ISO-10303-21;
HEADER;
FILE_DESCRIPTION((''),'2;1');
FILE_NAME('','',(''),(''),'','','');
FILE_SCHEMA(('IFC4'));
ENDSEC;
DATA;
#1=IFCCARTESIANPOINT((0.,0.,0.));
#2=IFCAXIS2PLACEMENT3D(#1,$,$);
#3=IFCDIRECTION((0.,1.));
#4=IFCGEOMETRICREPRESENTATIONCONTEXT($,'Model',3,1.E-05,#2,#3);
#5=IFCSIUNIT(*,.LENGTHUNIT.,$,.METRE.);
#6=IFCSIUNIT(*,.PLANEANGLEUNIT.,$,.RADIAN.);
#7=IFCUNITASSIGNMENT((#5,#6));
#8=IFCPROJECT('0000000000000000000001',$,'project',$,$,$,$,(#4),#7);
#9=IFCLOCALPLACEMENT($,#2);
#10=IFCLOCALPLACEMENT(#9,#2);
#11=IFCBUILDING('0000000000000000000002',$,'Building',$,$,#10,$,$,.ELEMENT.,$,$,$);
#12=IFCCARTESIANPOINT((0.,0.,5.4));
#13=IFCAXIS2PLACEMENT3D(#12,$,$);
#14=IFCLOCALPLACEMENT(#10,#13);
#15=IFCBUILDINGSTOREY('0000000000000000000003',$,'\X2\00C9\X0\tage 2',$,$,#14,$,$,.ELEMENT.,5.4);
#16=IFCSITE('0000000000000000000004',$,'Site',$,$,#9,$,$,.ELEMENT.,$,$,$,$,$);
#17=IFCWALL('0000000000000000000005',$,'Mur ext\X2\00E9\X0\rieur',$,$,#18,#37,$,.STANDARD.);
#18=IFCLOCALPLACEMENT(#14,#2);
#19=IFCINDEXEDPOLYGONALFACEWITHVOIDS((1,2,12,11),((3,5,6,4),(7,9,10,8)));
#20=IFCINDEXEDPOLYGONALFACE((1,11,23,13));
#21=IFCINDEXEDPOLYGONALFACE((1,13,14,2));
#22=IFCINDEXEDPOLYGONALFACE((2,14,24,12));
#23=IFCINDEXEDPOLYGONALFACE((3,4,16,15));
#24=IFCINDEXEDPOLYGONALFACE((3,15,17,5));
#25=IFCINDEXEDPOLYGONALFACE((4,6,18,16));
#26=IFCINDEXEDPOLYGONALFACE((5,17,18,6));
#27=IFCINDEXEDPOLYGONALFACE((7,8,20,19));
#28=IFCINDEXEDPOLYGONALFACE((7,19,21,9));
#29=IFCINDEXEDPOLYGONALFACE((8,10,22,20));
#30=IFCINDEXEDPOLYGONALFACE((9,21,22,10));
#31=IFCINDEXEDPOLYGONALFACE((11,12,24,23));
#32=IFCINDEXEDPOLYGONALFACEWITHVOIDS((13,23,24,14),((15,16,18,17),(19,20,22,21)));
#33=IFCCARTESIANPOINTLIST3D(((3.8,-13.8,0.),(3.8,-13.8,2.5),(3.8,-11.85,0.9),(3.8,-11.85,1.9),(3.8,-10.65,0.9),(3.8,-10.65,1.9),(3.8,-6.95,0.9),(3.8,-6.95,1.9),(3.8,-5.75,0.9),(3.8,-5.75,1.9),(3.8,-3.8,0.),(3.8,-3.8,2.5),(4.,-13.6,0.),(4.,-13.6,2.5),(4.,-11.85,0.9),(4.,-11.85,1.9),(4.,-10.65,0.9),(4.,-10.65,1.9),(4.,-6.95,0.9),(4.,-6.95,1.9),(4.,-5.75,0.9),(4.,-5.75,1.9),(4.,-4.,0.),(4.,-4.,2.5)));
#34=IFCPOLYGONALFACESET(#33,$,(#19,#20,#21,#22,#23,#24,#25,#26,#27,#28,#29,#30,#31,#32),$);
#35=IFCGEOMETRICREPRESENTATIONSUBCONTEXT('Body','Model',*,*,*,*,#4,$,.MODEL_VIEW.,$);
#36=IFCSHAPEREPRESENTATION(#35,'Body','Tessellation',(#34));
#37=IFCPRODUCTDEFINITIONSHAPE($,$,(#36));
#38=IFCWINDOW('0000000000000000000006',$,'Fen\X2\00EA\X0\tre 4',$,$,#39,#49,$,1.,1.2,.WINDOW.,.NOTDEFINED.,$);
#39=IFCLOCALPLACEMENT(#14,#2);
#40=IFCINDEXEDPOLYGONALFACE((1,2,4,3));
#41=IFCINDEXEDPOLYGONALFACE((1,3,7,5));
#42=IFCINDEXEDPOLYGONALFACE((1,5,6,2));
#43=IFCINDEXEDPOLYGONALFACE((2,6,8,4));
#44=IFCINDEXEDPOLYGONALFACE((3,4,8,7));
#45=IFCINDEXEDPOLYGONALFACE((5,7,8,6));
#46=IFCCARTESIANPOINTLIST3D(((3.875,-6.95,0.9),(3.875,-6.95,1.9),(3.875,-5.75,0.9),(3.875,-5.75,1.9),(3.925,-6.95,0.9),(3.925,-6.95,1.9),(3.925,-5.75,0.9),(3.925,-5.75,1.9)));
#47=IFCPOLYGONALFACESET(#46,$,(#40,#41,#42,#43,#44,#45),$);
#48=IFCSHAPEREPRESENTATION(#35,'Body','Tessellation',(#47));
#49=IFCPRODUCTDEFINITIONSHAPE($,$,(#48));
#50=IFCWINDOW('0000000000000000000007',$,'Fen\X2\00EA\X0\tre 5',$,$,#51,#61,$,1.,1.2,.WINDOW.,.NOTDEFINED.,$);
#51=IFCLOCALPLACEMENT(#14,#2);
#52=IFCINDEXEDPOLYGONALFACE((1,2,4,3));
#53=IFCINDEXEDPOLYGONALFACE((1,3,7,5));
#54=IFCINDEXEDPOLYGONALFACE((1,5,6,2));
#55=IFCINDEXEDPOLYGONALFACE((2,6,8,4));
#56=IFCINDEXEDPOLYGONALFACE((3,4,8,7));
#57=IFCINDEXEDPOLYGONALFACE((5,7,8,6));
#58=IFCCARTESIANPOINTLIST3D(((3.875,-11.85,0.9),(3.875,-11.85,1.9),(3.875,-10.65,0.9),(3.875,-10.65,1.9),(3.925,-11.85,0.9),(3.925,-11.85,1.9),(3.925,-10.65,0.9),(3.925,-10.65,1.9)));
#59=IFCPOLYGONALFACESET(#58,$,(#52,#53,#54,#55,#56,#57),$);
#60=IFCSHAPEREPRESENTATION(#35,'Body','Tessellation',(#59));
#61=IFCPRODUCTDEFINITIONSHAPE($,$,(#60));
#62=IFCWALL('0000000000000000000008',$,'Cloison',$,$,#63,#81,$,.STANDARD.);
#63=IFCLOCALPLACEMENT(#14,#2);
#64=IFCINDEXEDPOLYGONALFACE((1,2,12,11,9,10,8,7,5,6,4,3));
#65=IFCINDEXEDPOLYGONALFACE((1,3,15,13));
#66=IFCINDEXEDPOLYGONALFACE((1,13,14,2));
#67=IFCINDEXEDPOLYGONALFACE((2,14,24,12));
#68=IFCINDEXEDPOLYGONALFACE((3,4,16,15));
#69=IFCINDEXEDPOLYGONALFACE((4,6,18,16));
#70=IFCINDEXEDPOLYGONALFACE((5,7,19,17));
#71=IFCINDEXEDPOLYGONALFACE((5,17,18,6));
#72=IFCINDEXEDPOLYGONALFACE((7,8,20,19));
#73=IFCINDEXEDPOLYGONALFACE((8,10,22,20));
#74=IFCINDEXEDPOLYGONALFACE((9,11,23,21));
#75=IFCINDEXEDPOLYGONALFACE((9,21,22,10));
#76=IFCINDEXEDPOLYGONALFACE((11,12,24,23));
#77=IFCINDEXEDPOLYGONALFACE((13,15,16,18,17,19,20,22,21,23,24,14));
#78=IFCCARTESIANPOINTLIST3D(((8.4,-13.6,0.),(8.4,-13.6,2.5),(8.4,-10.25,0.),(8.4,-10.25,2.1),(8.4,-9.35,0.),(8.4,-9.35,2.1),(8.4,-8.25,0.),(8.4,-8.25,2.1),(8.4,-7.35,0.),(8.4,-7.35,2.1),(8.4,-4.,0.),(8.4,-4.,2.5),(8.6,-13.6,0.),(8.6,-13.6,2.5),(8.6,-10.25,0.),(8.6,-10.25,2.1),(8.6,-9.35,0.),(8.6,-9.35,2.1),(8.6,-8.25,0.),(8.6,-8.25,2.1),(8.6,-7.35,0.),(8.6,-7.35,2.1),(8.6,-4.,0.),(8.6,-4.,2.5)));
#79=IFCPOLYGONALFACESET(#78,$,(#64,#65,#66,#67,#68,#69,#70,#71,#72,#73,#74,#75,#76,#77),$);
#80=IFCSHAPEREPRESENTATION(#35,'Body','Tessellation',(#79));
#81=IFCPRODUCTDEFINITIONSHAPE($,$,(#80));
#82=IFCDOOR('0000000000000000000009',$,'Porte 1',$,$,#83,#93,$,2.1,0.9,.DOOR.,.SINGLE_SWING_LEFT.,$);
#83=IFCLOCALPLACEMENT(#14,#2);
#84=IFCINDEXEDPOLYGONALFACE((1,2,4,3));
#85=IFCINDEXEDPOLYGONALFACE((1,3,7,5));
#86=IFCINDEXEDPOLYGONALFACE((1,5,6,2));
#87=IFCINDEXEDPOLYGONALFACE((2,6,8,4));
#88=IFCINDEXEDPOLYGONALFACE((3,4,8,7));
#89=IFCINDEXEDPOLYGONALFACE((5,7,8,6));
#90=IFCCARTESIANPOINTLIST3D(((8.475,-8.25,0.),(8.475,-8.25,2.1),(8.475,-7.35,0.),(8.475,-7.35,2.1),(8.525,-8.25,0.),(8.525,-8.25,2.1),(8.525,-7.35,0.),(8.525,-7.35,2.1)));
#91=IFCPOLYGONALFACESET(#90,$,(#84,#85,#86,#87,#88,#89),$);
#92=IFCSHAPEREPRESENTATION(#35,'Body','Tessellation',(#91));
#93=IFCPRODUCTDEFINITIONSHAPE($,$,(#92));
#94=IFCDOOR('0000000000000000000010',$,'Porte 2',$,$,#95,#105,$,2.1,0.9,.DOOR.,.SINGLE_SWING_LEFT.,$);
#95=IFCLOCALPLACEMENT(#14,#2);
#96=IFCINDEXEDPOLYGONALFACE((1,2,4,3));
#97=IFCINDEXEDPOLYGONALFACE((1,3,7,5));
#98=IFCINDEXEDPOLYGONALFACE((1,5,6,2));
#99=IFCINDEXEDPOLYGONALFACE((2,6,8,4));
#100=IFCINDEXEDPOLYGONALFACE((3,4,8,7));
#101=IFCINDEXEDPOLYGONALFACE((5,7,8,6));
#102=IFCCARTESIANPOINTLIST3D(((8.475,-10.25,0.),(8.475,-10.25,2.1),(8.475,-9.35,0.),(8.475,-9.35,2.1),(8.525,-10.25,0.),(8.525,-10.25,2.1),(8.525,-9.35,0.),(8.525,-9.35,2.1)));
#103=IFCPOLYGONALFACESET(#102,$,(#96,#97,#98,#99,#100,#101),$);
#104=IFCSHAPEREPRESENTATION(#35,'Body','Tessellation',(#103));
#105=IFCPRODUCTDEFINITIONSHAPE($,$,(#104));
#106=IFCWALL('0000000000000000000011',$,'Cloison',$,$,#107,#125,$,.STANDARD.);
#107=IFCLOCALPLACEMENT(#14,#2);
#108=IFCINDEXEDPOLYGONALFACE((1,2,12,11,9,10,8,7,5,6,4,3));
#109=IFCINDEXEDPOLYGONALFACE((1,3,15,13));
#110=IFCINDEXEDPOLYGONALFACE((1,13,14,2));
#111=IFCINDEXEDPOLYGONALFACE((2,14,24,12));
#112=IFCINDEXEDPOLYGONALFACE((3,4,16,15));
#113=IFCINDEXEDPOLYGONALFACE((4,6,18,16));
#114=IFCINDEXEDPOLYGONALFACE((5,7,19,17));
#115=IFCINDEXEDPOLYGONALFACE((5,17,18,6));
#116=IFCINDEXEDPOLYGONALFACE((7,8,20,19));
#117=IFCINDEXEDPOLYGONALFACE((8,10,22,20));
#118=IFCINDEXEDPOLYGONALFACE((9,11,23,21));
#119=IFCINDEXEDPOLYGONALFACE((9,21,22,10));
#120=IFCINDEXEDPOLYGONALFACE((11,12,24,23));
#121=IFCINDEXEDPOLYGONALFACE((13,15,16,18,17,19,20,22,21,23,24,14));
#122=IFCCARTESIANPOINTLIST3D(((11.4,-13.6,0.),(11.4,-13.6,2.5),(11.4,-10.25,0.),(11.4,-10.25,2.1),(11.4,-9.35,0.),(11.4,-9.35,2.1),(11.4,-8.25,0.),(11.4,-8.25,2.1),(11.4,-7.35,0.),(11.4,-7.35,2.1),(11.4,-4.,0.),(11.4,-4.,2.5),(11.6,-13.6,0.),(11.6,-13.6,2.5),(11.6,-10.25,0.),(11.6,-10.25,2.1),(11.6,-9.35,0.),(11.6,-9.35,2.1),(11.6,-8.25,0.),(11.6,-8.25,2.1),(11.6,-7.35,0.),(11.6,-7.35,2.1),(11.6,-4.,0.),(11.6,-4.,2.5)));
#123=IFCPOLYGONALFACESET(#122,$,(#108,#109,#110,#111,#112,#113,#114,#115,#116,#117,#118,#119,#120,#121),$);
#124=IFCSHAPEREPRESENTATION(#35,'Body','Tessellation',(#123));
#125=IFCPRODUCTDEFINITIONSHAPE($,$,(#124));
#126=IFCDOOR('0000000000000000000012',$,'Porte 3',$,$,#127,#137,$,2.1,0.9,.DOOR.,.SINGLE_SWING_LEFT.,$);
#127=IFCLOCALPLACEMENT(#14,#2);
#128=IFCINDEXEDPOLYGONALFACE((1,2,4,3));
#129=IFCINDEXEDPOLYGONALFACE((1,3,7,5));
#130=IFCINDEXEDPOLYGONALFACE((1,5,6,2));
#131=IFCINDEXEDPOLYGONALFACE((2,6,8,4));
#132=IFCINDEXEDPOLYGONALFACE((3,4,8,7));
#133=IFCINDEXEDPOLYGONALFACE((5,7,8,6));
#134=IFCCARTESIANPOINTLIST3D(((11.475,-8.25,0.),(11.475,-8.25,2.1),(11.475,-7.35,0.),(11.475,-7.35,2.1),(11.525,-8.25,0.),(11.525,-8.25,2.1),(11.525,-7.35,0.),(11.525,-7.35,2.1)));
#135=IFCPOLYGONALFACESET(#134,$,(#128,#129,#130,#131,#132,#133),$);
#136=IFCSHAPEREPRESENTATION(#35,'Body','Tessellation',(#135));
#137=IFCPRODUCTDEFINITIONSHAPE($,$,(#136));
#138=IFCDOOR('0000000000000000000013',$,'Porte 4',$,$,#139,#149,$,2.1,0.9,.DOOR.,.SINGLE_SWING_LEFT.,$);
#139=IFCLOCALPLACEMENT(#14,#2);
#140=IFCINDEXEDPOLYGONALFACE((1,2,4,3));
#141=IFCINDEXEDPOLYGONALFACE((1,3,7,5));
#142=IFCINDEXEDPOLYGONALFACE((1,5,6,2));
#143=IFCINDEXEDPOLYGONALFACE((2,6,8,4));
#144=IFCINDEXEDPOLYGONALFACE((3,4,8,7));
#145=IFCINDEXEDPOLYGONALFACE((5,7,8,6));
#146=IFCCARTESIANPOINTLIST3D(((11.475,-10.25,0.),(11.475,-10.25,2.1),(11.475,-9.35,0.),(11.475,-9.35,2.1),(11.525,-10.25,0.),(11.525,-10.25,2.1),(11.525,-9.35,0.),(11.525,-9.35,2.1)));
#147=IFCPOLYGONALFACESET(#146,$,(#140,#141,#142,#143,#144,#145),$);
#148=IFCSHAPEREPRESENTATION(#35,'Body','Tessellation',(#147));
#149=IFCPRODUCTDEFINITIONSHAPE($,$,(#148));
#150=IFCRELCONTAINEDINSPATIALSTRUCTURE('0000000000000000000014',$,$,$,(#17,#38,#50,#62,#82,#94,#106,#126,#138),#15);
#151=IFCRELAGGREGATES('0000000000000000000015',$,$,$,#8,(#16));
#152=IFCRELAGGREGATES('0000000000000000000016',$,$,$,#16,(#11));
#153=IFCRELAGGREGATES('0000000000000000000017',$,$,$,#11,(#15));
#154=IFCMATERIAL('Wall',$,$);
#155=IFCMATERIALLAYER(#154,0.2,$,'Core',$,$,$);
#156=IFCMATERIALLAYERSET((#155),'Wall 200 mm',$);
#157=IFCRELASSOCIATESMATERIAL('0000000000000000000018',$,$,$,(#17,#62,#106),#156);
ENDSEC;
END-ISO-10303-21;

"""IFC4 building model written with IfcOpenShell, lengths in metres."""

from ifc_helpers import new_model, si_unit, direction, frame, origin, origin_2d, place, context, subcontext, project, spatial, polyline, rectangle, outline, extrude, material, layer, layer_set, layer_usage, element, fill, save


model = new_model("IFC4")

# Units and contexts
model_context = context("Model", 3, precision=1e-05, world=origin(), true_north=direction((0.0, 1.0)))
body_context = subcontext(model_context, "Body", "Model", "MODEL_VIEW")
ifc_project = project(units=[si_unit("LENGTHUNIT", "METRE"), si_unit("PLANEANGLEUNIT", "RADIAN")], contexts=[model_context])

# Site, building, storey
site_placement = place(None, origin())
site = spatial("IfcSite", under=ifc_project, at=site_placement, Name="Site", CompositionType="ELEMENT")
building_placement = place(site_placement, origin())
building = spatial("IfcBuilding", under=site, at=building_placement, Name="Building", CompositionType="ELEMENT")
storey_placement = place(building_placement, frame((0.0, 0.0, 5.4)))
storey = spatial("IfcBuildingStorey", under=building, at=storey_placement, Name="Étage 2", CompositionType="ELEMENT", Elevation=5.4)

# Shared definitions
ifc_material = material(Name="Wall")
ifc_layer = layer(ifc_material, 0.2, Name="Core")
ifc_layer_set = layer_set([ifc_layer], Name="Wall 200 mm")
ifc_layer_usage = layer_usage(ifc_layer_set, "AXIS2", "POSITIVE", -0.1)

# Wall, openings, windows
wall_1_placement = place(storey_placement, frame((3.9, -13.7, 0.0), z_axis=(0.0, 0.0, 1.0), x_axis=(0.0, 1.0, 0.0)))
wall_1 = element("IfcWall", 1, at=wall_1_placement, inside=storey, material=ifc_layer_usage, Name="Mur extérieur", PredefinedType="STANDARD", context=body_context, shape_type="SweptSolid", body=[
    extrude(outline(polyline([(0.0, 0.0), (0.1, -0.1), (9.7, -0.1), (9.8, 0.0), (9.9, 0.1), (-0.1, 0.1), (0.0, 0.0)])), origin(), (0.0, 0.0, 1.0), 2.5),
])
opening_1_placement = place(wall_1_placement, frame((7.35, 0.0, 0.9)))
opening_1 = element("IfcOpeningElement", 2, at=opening_1_placement, cuts=wall_1, PredefinedType="OPENING", context=body_context, shape_type="SweptSolid", body=[
    extrude(rectangle(XDim=1.2, YDim=0.4, at=origin_2d()), origin(), (0.0, 0.0, 1.0), 1.0),
])
opening_2_placement = place(wall_1_placement, frame((2.45, 0.0, 0.9)))
opening_2 = element("IfcOpeningElement", 3, at=opening_2_placement, cuts=wall_1, PredefinedType="OPENING", context=body_context, shape_type="SweptSolid", body=[
    extrude(rectangle(XDim=1.2, YDim=0.4, at=origin_2d()), origin(), (0.0, 0.0, 1.0), 1.0),
])
window_1_placement = place(opening_1_placement, origin())
window_1 = element("IfcWindow", 4, at=window_1_placement, inside=storey, Name="Fenêtre 4", OverallHeight=1.0, OverallWidth=1.2, PartitioningType="NOTDEFINED", PredefinedType="WINDOW", context=body_context, shape_type="SweptSolid", body=[
    extrude(rectangle(XDim=1.2, YDim=0.05, at=origin_2d()), origin(), (0.0, 0.0, 1.0), 1.0),
])
fill(opening_1, window_1)
window_2_placement = place(opening_2_placement, origin())
window_2 = element("IfcWindow", 5, at=window_2_placement, inside=storey, Name="Fenêtre 5", OverallHeight=1.0, OverallWidth=1.2, PartitioningType="NOTDEFINED", PredefinedType="WINDOW", context=body_context, shape_type="SweptSolid", body=[
    extrude(rectangle(XDim=1.2, YDim=0.05, at=origin_2d()), origin(), (0.0, 0.0, 1.0), 1.0),
])
fill(opening_2, window_2)

# Walls, openings, doors
wall_2_placement = place(storey_placement, frame((8.5, -3.9, 0.0), z_axis=(0.0, 0.0, 1.0), x_axis=(0.0, -1.0, 0.0)))
wall_2 = element("IfcWall", 6, at=wall_2_placement, inside=storey, material=ifc_layer_usage, Name="Cloison", PredefinedType="STANDARD", context=body_context, shape_type="SweptSolid", body=[
    extrude(outline(polyline([(0.1, 0.0), (0.1, -0.1), (9.7, -0.1), (9.7, 0.0), (9.7, 0.1), (0.1, 0.1), (0.1, 0.0)])), origin(), (0.0, 0.0, 1.0), 2.5),
])
opening_3_placement = place(wall_2_placement, frame((3.9, 0.0, 0.0)))
opening_3 = element("IfcOpeningElement", 7, at=opening_3_placement, cuts=wall_2, PredefinedType="OPENING", context=body_context, shape_type="SweptSolid", body=[
    extrude(rectangle(XDim=0.9, YDim=0.4, at=origin_2d()), origin(), (0.0, 0.0, 1.0), 2.1),
])
opening_4_placement = place(wall_2_placement, frame((5.9, 0.0, 0.0)))
opening_4 = element("IfcOpeningElement", 8, at=opening_4_placement, cuts=wall_2, PredefinedType="OPENING", context=body_context, shape_type="SweptSolid", body=[
    extrude(rectangle(XDim=0.9, YDim=0.4, at=origin_2d()), origin(), (0.0, 0.0, 1.0), 2.1),
])
door_1_placement = place(opening_3_placement, origin())
door_1 = element("IfcDoor", 9, at=door_1_placement, inside=storey, Name="Porte 1", OperationType="SINGLE_SWING_LEFT", OverallHeight=2.1, OverallWidth=0.9, PredefinedType="DOOR", context=body_context, shape_type="SweptSolid", body=[
    extrude(rectangle(XDim=0.9, YDim=0.05, at=origin_2d()), origin(), (0.0, 0.0, 1.0), 2.1),
])
fill(opening_3, door_1)
door_2_placement = place(opening_4_placement, origin())
door_2 = element("IfcDoor", 10, at=door_2_placement, inside=storey, Name="Porte 2", OperationType="SINGLE_SWING_LEFT", OverallHeight=2.1, OverallWidth=0.9, PredefinedType="DOOR", context=body_context, shape_type="SweptSolid", body=[
    extrude(rectangle(XDim=0.9, YDim=0.05, at=origin_2d()), origin(), (0.0, 0.0, 1.0), 2.1),
])
fill(opening_4, door_2)
wall_3_placement = place(storey_placement, frame((11.5, -3.9, 0.0), z_axis=(0.0, 0.0, 1.0), x_axis=(0.0, -1.0, 0.0)))
wall_3 = element("IfcWall", 11, at=wall_3_placement, inside=storey, material=ifc_layer_usage, Name="Cloison", PredefinedType="STANDARD", context=body_context, shape_type="SweptSolid", body=[
    extrude(outline(polyline([(0.1, 0.0), (0.1, -0.1), (9.7, -0.1), (9.7, 0.0), (9.7, 0.1), (0.1, 0.1), (0.1, 0.0)])), origin(), (0.0, 0.0, 1.0), 2.5),
])
opening_5_placement = place(wall_3_placement, frame((3.9, 0.0, 0.0)))
opening_5 = element("IfcOpeningElement", 12, at=opening_5_placement, cuts=wall_3, PredefinedType="OPENING", context=body_context, shape_type="SweptSolid", body=[
    extrude(rectangle(XDim=0.9, YDim=0.4, at=origin_2d()), origin(), (0.0, 0.0, 1.0), 2.1),
])
opening_6_placement = place(wall_3_placement, frame((5.9, 0.0, 0.0)))
opening_6 = element("IfcOpeningElement", 13, at=opening_6_placement, cuts=wall_3, PredefinedType="OPENING", context=body_context, shape_type="SweptSolid", body=[
    extrude(rectangle(XDim=0.9, YDim=0.4, at=origin_2d()), origin(), (0.0, 0.0, 1.0), 2.1),
])
door_3_placement = place(opening_5_placement, origin())
door_3 = element("IfcDoor", 14, at=door_3_placement, inside=storey, Name="Porte 3", OperationType="SINGLE_SWING_LEFT", OverallHeight=2.1, OverallWidth=0.9, PredefinedType="DOOR", context=body_context, shape_type="SweptSolid", body=[
    extrude(rectangle(XDim=0.9, YDim=0.05, at=origin_2d()), origin(), (0.0, 0.0, 1.0), 2.1),
])
fill(opening_5, door_3)
door_4_placement = place(opening_6_placement, origin())
door_4 = element("IfcDoor", 15, at=door_4_placement, inside=storey, Name="Porte 4", OperationType="SINGLE_SWING_LEFT", OverallHeight=2.1, OverallWidth=0.9, PredefinedType="DOOR", context=body_context, shape_type="SweptSolid", body=[
    extrude(rectangle(XDim=0.9, YDim=0.05, at=origin_2d()), origin(), (0.0, 0.0, 1.0), 2.1),
])
fill(opening_6, door_4)

save(model, "model.ifc")
